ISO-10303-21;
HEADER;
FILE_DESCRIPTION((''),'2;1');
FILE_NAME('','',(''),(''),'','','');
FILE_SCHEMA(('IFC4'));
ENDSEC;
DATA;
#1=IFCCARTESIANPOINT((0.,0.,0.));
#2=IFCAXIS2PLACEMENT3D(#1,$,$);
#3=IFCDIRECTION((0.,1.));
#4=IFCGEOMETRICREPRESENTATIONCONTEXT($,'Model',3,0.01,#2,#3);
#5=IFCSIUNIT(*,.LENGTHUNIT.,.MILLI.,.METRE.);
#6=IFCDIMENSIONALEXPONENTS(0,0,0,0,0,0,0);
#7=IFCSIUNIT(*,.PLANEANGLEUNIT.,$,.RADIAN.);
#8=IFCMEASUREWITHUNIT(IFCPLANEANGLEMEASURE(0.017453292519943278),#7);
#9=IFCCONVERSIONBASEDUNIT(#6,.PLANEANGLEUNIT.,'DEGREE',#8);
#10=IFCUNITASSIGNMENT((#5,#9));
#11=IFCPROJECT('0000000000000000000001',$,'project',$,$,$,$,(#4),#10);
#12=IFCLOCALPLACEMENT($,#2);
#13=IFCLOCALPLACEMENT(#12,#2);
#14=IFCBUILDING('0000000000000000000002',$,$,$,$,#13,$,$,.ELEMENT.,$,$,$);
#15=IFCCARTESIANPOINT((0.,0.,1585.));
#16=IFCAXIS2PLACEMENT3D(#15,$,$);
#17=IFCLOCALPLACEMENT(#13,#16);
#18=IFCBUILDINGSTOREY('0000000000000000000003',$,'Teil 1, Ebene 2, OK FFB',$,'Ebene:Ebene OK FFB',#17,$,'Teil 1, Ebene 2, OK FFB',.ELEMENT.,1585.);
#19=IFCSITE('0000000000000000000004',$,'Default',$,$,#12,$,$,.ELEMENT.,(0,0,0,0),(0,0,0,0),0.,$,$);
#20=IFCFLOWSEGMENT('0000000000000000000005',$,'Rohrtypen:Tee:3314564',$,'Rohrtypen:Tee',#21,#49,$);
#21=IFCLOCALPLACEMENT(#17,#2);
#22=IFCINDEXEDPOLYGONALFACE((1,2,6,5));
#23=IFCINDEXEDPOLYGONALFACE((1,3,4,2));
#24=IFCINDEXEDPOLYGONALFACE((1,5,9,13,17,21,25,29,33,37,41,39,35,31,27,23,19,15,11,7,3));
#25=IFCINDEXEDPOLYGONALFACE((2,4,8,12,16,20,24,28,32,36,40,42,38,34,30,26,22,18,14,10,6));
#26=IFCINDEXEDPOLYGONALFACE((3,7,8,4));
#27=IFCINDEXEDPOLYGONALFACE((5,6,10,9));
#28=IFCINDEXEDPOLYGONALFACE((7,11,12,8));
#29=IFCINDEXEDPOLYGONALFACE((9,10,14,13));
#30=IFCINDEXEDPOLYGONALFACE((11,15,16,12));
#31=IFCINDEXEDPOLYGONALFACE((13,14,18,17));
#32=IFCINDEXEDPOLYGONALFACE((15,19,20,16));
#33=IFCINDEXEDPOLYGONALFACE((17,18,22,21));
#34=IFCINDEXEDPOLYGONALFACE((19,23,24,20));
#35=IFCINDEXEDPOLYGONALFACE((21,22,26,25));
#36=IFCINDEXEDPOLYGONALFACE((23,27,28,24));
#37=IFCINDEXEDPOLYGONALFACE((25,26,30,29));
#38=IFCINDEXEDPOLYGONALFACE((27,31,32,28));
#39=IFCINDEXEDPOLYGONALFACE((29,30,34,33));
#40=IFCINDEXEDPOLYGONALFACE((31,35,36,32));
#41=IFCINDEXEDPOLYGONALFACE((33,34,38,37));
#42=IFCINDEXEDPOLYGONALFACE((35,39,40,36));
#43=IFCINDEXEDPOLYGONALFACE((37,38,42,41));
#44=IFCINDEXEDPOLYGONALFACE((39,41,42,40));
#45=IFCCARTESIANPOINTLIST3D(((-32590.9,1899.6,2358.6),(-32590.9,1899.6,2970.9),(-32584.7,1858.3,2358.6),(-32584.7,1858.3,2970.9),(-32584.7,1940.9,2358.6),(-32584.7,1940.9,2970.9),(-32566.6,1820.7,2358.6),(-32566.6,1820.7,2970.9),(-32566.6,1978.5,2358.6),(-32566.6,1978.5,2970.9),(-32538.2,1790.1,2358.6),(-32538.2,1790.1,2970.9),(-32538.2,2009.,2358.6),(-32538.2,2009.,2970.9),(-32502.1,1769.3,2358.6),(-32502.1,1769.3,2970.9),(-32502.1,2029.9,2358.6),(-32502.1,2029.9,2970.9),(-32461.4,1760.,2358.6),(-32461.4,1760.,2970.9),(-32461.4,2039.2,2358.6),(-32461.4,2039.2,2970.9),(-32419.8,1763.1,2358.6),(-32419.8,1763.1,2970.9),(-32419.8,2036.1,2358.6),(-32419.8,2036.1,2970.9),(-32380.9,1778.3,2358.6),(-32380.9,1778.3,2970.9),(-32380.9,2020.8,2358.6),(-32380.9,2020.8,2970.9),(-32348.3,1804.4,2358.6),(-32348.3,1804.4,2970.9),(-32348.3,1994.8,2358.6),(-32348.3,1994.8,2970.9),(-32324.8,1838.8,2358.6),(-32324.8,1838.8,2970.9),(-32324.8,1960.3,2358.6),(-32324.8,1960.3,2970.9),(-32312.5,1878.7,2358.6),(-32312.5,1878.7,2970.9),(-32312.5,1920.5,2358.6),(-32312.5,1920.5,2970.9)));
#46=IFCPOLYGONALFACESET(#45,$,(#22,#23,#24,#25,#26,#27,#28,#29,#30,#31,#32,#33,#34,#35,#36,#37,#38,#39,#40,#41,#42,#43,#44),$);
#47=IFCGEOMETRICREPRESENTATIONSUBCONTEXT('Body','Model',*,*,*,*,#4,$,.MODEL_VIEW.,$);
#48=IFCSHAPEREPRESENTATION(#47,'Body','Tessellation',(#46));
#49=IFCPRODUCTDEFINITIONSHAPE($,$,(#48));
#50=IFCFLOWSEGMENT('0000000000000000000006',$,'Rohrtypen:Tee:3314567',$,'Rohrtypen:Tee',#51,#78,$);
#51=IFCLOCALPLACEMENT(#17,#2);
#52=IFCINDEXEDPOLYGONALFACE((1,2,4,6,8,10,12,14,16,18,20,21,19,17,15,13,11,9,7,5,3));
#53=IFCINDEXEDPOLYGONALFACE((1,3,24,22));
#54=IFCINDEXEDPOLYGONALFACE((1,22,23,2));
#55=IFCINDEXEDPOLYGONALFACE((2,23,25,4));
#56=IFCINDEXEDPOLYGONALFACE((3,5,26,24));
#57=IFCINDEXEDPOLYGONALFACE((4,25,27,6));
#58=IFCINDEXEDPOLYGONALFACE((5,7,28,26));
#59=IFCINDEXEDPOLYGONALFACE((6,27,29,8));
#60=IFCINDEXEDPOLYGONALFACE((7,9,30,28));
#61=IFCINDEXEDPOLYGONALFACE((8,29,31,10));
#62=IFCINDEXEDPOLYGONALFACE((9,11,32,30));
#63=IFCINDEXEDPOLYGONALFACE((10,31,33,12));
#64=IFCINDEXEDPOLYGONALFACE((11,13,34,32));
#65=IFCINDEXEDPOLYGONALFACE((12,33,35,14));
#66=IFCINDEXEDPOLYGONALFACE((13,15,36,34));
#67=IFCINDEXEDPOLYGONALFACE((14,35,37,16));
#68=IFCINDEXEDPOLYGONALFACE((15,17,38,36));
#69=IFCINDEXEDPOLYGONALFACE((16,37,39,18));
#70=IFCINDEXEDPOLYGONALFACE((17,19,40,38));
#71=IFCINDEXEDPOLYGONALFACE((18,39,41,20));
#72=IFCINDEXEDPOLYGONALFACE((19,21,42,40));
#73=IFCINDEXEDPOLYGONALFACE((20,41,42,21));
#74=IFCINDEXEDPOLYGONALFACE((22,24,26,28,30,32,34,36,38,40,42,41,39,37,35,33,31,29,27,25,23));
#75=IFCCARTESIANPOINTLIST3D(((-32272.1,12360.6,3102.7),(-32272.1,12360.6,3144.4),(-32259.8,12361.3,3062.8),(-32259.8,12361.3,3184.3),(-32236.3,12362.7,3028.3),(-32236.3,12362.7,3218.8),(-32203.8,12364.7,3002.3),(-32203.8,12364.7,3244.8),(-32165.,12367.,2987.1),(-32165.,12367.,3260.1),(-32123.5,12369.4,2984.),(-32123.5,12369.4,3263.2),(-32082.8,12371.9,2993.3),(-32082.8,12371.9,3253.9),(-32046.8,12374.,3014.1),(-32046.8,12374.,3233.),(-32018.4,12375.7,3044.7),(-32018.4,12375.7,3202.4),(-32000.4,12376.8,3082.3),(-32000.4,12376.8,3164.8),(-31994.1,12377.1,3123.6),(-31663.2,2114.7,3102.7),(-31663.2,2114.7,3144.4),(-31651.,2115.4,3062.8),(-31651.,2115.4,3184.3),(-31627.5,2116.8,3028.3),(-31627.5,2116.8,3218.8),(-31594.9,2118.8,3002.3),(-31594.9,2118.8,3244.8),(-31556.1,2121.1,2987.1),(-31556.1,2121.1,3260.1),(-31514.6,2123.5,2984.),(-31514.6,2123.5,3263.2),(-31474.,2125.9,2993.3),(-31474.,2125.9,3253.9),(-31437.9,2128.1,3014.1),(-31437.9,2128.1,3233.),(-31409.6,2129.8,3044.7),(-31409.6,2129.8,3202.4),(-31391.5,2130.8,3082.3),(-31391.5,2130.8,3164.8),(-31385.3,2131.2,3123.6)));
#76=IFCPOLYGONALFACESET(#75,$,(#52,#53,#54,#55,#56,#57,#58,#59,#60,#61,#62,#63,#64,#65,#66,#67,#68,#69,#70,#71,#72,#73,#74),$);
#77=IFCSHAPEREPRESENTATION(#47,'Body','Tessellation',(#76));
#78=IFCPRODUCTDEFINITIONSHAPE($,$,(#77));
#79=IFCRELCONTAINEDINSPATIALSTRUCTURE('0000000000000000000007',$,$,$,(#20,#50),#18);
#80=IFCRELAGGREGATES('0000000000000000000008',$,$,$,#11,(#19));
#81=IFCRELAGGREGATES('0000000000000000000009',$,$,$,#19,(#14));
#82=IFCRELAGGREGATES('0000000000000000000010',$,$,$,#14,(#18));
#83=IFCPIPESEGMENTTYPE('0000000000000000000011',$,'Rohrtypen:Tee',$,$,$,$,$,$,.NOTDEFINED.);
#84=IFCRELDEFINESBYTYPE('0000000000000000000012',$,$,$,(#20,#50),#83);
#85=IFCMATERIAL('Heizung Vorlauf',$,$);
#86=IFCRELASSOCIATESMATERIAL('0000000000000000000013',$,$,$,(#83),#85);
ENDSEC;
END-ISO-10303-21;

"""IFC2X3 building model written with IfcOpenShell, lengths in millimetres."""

from ifc_helpers import new_model, entity, si_unit, converted_unit, direction, frame, frame_2d, origin, origin_2d_with_axis, place, context, subcontext, project, spatial, circle, extrude, material, type_object, element, save


model = new_model("IFC2X3")

# Units and contexts
model_context = context("Model", 3, precision=0.01, world=origin(), true_north=direction((0.0, 1.0)))
body_context = subcontext(model_context, "Body", "Model", "MODEL_VIEW")
ifc_project = project(units=[si_unit("LENGTHUNIT", "METRE", prefix="MILLI"), converted_unit("PLANEANGLEUNIT", "DEGREE", entity("IfcPlaneAngleMeasure", 0.017453292519943278), si_unit("PLANEANGLEUNIT", "RADIAN"), dimensions=[0, 0, 0, 0, 0, 0, 0])], contexts=[model_context])

# Site, building, storey
site_placement = place(None, origin())
site = spatial("IfcSite", under=ifc_project, at=site_placement, Name="Default", CompositionType="ELEMENT", RefLatitude=(0, 0, 0, 0), RefLongitude=(0, 0, 0, 0), RefElevation=0.0)
building_placement = place(site_placement, origin())
building = spatial("IfcBuilding", under=site, at=building_placement, CompositionType="ELEMENT")
storey_placement = place(building_placement, frame((0.0, 0.0, 1585.0)))
storey = spatial("IfcBuildingStorey", under=building, at=storey_placement, Name="Teil 1, Ebene 2, OK FFB", ObjectType="Ebene:Ebene OK FFB", LongName="Teil 1, Ebene 2, OK FFB", CompositionType="ELEMENT", Elevation=1585.0)

# Flow segments
ifc_material = material(Name="Heizung Vorlauf")
pipe_segment_type = type_object("IfcPipeSegmentType", Name="Rohrtypen:Tee", PredefinedType="NOTDEFINED", material=ifc_material)
flow_segment_1_placement = place(storey_placement, origin())
element("IfcFlowSegment", 1, at=flow_segment_1_placement, inside=storey, type_object=pipe_segment_type, Name="Rohrtypen:Tee:3314564", ObjectType="Rohrtypen:Tee", context=body_context, shape_type="SweptSolid", body=[
    extrude(circle(Radius=140.0, at=frame_2d((0.0, 0.0), x_axis=(1.0, 0.0))), frame((-32450.9, 1899.6, 2358.6), z_axis=(0.0, 0.0, 1.0), x_axis=(-1.0, 0.0, 0.0)), (0.0, 0.0, 1.0), 612.3),
])
flow_segment_2_placement = place(storey_placement, origin())
element("IfcFlowSegment", 2, at=flow_segment_2_placement, inside=storey, type_object=pipe_segment_type, Name="Rohrtypen:Tee:3314567", ObjectType="Rohrtypen:Tee", context=body_context, shape_type="SweptSolid", body=[
    extrude(circle(Radius=140.0, at=origin_2d_with_axis()), frame((-31525.0, 2122.9, 3123.6), z_axis=(-0.059319, 0.998239, 0.0), x_axis=(0.998239, 0.059319, 0.0)), (0.0, 0.0, 1.0), 10264.0),
])

save(model, "model.ifc")
